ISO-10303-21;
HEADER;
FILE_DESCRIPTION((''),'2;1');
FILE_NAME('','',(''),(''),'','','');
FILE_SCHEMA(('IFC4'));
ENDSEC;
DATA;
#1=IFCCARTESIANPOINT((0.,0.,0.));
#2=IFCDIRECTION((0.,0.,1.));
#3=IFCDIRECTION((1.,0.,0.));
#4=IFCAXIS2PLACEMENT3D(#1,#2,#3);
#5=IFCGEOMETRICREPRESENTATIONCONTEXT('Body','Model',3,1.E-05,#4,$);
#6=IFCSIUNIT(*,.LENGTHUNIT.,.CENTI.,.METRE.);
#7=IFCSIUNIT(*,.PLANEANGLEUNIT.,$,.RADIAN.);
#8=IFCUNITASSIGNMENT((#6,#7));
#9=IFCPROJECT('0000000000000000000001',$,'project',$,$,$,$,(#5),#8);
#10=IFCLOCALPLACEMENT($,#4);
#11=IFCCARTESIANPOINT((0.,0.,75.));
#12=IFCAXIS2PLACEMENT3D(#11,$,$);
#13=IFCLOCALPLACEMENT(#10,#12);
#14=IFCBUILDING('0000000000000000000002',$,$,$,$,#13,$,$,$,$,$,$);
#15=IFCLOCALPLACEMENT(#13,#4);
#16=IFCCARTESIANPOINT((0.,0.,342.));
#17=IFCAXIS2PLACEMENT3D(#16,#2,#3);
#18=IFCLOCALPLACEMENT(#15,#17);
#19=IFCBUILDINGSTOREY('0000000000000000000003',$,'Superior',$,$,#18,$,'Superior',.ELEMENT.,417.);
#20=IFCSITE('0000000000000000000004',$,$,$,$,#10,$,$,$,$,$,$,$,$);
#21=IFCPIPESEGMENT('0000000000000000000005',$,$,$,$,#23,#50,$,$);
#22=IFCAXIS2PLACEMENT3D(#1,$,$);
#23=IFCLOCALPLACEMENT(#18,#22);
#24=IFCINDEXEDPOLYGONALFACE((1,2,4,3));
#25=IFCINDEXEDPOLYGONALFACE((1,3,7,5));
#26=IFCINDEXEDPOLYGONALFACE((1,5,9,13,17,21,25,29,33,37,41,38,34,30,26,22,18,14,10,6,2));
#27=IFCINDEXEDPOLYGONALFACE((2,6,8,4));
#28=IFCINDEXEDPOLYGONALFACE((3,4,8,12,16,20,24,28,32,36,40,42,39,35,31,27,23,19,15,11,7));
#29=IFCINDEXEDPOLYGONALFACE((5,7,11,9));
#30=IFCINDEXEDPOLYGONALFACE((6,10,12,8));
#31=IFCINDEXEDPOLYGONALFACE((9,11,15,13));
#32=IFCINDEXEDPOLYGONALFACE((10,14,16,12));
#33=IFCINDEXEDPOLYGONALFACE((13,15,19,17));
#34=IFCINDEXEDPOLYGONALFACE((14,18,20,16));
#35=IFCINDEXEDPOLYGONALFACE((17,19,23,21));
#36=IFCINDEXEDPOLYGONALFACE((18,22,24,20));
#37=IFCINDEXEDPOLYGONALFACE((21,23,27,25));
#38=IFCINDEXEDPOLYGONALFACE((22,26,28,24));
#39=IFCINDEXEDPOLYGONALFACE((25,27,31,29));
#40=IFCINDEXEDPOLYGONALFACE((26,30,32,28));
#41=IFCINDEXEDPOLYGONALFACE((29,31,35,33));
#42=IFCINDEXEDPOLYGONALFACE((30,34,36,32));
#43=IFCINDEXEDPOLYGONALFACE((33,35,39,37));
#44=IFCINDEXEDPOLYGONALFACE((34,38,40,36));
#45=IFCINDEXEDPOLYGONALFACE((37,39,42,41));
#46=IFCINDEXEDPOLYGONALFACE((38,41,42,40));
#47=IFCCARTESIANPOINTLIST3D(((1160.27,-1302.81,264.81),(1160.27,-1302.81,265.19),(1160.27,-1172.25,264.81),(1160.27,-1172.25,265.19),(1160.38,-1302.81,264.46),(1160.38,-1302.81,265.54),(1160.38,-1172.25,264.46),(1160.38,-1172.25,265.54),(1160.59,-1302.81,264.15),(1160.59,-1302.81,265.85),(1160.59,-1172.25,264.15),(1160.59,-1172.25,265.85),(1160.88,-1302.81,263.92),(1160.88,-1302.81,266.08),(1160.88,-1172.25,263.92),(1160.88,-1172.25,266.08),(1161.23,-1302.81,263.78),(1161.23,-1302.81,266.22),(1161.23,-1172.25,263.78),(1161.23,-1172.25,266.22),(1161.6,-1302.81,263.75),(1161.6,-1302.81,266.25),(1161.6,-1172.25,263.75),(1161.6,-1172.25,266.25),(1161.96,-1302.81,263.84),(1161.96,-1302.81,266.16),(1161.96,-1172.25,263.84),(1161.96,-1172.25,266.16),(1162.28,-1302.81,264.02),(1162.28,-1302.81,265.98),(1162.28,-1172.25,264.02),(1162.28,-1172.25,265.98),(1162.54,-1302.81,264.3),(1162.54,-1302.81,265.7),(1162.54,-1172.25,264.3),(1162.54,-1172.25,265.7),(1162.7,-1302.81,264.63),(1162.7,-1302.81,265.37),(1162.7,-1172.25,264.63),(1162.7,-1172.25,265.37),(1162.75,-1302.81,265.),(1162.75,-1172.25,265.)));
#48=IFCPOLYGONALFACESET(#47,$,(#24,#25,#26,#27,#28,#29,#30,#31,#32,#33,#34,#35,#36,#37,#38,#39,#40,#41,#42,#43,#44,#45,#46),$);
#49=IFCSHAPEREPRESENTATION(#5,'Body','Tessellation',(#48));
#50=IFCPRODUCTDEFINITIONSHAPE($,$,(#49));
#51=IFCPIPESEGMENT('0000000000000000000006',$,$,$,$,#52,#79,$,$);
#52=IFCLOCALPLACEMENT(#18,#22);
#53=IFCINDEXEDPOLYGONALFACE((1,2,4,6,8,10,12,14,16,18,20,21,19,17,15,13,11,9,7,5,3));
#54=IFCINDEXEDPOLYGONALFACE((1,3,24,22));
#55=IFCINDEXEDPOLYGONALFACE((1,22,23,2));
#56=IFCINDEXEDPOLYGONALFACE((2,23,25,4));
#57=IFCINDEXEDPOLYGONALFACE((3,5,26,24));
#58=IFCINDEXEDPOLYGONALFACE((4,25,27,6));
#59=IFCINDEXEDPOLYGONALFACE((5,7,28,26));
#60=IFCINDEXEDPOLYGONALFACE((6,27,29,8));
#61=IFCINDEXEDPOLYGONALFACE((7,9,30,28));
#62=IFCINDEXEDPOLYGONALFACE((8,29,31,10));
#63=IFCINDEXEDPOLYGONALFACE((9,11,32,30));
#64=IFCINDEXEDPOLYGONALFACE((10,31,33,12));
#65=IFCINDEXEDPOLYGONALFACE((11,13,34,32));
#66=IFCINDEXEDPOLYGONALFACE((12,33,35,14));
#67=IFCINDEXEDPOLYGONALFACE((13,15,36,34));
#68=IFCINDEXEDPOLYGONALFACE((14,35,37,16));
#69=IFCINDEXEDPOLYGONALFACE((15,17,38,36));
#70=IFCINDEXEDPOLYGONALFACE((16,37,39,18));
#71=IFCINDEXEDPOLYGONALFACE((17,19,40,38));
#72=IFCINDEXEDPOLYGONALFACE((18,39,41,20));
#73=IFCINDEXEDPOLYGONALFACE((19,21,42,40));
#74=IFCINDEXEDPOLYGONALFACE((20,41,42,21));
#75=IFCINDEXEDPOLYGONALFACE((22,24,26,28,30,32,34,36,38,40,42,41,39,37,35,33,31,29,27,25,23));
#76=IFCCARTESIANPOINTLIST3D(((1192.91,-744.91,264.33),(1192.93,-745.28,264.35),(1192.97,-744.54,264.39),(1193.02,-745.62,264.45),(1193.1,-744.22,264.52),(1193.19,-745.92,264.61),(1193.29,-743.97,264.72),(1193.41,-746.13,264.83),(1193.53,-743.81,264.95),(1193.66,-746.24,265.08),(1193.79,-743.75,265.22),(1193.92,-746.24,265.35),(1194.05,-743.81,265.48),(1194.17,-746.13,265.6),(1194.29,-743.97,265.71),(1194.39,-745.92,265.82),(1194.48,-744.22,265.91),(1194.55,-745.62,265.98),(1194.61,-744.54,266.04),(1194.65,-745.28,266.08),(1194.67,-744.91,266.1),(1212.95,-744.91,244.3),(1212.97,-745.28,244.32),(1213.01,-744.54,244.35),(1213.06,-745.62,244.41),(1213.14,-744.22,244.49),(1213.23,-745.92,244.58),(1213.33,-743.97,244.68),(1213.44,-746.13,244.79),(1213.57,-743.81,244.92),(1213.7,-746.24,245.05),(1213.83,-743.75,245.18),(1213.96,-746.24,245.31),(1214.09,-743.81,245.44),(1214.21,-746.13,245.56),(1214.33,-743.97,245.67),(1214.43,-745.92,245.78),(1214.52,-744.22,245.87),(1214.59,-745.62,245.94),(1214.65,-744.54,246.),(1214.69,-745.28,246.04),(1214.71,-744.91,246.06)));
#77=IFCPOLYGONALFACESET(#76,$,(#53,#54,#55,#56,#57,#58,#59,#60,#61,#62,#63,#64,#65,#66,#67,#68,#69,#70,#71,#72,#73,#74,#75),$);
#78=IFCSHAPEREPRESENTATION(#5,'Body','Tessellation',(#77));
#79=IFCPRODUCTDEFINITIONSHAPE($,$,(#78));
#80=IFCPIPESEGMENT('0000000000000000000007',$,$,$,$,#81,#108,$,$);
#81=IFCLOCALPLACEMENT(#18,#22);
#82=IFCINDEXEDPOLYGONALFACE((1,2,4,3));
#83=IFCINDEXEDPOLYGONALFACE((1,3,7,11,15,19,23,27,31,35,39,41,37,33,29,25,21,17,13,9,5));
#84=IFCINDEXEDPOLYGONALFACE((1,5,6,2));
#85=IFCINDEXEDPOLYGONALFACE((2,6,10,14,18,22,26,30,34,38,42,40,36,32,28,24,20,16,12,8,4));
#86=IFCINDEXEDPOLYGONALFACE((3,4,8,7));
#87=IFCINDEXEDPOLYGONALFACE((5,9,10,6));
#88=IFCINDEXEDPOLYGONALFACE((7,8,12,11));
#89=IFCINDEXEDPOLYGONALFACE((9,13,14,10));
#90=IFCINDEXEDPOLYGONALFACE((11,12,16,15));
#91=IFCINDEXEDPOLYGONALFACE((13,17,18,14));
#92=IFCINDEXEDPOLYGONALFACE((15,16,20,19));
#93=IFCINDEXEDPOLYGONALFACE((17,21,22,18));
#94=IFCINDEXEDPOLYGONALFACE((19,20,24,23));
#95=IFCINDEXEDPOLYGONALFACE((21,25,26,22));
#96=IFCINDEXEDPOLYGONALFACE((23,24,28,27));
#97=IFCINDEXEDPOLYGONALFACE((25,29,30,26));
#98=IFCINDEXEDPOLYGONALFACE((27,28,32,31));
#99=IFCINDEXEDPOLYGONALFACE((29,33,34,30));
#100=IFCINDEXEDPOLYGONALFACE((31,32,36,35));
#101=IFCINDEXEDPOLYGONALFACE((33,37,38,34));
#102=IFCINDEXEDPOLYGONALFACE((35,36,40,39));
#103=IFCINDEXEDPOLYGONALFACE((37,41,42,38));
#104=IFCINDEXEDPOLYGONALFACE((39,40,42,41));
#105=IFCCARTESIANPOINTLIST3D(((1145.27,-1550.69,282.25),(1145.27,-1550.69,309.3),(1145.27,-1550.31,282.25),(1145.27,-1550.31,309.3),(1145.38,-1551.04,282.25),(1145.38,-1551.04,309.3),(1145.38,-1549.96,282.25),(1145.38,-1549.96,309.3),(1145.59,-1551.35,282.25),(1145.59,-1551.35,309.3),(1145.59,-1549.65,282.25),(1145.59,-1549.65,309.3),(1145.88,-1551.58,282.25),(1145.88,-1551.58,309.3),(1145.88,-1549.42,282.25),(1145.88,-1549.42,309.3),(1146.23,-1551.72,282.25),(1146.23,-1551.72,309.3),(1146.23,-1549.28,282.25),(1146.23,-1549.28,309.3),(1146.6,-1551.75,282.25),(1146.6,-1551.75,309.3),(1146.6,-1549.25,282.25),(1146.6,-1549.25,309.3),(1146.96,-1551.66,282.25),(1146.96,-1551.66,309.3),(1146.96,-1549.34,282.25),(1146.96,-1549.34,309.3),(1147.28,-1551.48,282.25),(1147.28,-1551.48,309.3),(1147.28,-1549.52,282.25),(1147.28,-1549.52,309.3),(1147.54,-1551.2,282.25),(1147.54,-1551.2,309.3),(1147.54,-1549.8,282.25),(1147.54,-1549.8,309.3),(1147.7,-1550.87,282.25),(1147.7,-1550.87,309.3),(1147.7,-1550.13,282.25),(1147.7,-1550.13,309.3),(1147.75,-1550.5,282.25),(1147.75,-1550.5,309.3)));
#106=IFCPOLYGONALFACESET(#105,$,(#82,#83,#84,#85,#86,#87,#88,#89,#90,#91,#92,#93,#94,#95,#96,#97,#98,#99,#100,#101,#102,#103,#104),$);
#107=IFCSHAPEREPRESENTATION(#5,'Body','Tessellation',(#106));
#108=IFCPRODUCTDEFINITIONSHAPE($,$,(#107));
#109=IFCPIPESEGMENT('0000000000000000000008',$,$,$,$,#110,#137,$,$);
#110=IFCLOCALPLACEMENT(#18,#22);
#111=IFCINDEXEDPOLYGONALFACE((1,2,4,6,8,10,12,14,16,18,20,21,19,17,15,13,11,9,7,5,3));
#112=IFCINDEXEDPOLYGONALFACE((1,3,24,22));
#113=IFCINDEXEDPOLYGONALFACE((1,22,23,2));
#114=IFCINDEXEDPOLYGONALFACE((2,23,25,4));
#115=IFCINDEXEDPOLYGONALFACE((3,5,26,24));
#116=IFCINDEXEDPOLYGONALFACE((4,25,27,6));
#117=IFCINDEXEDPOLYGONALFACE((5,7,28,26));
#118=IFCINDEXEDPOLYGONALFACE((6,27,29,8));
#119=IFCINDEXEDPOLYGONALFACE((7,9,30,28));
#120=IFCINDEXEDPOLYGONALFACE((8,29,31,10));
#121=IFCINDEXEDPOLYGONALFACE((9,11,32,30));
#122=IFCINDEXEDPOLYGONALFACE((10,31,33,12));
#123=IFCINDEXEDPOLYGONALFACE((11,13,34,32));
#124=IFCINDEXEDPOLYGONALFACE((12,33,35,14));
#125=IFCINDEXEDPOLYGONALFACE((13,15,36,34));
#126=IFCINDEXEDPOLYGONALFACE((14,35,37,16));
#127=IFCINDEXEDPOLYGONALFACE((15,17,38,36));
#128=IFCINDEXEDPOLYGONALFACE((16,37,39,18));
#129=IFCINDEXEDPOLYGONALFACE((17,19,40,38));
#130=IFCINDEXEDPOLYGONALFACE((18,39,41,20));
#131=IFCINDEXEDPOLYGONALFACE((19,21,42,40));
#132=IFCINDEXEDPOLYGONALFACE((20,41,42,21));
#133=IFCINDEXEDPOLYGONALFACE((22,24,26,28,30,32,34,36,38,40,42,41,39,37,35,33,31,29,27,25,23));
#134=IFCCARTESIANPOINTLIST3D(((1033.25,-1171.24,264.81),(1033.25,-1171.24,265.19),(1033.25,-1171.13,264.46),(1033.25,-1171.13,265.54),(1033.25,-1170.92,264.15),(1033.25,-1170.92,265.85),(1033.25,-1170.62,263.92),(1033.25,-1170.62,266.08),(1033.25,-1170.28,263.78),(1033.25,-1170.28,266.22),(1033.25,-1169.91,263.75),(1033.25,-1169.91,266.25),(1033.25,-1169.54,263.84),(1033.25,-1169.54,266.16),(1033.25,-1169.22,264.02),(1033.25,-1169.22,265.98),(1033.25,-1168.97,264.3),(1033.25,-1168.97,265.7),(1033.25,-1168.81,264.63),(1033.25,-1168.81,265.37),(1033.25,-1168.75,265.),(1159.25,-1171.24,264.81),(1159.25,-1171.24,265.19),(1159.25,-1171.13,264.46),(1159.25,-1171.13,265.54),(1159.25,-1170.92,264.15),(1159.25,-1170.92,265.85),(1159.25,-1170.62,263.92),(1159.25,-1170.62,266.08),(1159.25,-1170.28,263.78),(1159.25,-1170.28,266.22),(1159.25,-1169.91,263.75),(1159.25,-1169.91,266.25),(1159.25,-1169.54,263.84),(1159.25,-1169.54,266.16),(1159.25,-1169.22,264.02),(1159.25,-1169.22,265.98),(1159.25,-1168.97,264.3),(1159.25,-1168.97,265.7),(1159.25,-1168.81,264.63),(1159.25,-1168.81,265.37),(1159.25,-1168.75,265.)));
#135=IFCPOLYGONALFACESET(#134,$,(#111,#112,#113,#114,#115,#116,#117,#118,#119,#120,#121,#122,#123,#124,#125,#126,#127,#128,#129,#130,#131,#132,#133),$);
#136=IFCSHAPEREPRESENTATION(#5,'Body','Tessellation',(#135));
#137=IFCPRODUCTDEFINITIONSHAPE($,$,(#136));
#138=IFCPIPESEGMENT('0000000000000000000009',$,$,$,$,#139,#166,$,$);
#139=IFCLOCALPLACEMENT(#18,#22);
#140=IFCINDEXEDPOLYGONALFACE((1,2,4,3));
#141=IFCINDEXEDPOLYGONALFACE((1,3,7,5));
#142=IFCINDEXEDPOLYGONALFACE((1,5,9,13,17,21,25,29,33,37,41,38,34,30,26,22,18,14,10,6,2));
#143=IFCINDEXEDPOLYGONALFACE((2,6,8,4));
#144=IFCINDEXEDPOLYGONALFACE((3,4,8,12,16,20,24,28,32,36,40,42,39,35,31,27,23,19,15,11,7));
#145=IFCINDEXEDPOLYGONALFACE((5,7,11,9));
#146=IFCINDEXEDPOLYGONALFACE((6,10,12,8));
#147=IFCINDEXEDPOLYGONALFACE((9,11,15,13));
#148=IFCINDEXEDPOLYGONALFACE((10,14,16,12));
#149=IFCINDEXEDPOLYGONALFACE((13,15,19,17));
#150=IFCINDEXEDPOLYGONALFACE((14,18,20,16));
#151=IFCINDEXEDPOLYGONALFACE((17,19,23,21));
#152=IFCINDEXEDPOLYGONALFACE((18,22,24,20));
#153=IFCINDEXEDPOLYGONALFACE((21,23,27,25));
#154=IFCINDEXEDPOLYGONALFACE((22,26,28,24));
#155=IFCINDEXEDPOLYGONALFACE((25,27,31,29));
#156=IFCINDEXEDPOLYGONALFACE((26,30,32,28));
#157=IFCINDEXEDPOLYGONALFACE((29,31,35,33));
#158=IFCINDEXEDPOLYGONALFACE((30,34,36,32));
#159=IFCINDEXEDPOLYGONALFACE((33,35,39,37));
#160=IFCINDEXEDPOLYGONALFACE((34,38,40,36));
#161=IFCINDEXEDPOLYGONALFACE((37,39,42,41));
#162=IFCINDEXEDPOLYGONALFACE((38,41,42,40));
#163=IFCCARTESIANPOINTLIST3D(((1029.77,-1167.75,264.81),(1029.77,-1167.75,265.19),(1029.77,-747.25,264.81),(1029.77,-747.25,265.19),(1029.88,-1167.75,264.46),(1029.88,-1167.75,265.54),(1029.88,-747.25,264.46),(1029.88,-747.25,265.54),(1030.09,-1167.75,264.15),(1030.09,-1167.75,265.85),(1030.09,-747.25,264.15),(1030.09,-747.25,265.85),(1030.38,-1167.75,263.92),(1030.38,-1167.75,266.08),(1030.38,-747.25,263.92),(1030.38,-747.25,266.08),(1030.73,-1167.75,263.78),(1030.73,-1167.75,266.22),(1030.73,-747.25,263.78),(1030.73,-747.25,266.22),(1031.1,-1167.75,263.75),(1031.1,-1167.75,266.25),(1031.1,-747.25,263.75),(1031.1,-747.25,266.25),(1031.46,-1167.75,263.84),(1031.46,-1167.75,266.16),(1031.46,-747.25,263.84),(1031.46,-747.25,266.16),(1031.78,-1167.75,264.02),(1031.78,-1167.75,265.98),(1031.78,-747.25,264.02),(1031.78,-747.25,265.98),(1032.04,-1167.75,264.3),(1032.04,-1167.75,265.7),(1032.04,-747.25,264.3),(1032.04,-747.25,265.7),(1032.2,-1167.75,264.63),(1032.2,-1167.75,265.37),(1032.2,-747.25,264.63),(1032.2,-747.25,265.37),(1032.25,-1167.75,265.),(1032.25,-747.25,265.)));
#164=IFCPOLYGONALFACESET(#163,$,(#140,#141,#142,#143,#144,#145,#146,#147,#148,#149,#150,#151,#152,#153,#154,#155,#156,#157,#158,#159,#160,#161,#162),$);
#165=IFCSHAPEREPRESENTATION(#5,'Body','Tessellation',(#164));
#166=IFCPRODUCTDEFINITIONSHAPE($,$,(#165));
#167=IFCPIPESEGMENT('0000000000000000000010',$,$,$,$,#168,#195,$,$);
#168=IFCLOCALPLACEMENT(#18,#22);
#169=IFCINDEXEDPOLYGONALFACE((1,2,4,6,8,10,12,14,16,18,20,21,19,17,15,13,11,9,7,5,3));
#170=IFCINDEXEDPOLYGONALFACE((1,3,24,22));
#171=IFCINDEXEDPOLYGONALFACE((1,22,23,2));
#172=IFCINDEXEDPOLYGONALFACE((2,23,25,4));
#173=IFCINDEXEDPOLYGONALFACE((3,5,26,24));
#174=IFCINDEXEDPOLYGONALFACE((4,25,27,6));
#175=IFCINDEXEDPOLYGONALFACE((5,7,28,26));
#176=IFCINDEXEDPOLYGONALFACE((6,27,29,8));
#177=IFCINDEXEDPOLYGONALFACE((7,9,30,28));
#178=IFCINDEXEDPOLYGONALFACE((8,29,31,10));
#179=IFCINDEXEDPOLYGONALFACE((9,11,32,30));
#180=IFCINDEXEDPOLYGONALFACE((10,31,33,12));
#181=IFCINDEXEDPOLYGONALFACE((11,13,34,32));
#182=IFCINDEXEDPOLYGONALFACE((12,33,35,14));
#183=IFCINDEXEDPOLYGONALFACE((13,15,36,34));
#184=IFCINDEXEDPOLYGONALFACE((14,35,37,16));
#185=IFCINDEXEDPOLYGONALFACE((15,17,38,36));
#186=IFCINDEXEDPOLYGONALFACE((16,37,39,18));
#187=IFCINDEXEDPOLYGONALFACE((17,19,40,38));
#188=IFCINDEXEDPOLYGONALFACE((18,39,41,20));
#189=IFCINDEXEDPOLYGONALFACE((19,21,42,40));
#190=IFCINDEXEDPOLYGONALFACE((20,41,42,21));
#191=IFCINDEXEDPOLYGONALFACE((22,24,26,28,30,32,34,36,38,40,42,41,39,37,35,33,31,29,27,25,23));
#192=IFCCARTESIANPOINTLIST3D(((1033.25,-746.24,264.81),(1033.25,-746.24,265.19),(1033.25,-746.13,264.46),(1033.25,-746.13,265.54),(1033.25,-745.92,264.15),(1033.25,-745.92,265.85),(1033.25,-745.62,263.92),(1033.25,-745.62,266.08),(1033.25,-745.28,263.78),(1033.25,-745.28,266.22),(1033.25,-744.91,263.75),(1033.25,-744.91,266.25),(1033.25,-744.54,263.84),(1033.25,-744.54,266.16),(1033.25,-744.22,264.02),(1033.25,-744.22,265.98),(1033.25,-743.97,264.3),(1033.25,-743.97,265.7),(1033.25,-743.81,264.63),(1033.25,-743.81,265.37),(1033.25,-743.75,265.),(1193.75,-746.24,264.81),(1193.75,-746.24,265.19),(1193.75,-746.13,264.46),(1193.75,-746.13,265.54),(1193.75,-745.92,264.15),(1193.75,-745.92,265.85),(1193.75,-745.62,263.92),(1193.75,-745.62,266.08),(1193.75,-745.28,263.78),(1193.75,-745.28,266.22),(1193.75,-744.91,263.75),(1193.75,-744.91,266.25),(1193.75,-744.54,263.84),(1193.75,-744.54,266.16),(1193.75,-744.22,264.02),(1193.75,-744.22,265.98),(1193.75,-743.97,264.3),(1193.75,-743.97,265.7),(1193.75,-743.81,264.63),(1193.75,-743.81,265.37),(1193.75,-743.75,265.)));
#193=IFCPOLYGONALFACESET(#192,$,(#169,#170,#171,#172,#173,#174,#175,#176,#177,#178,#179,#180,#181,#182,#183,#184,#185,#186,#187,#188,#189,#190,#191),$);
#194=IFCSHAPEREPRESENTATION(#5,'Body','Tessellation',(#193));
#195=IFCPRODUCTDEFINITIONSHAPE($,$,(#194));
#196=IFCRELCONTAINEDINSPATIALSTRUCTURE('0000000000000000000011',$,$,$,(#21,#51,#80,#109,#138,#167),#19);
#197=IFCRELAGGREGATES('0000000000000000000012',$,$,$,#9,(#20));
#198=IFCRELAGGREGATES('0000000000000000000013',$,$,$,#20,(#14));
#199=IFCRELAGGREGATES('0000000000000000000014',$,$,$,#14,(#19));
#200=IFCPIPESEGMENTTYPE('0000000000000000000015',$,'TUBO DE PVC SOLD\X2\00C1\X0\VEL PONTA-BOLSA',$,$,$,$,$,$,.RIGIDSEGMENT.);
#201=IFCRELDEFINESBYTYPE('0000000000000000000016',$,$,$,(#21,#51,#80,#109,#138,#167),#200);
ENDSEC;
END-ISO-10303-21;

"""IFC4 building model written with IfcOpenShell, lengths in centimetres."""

from ifc_helpers import new_model, si_unit, frame, origin_with_axes, origin_2d_with_axis, place, context, project, spatial, circle, extrude, type_object, element, save


model = new_model("IFC4")

# Units and contexts
model_context = context("Model", 3, precision=1e-05, world=origin_with_axes(), identifier="Body")
ifc_project = project(units=[si_unit("LENGTHUNIT", "METRE", prefix="CENTI"), si_unit("PLANEANGLEUNIT", "RADIAN")], contexts=[model_context])

# Site, building, storey
site_placement = place(None, origin_with_axes())
site = spatial("IfcSite", under=ifc_project, at=site_placement)
building_placement = place(site_placement, frame((0.0, 0.0, 75.0)))
building = spatial("IfcBuilding", under=site, at=building_placement)
placement = place(building_placement, origin_with_axes())
storey_placement = place(placement, frame((0.0, 0.0, 342.0), z_axis=(0.0, 0.0, 1.0), x_axis=(1.0, 0.0, 0.0)))
storey = spatial("IfcBuildingStorey", under=building, at=storey_placement, Name="Superior", LongName="Superior", CompositionType="ELEMENT", Elevation=417.0)

# Pipe segments
pipe_segment_type_1 = type_object("IfcPipeSegmentType", Name="TUBO DE PVC SOLDÁVEL PONTA-BOLSA", PredefinedType="RIGIDSEGMENT")
pipe_segment_1_placement = place(storey_placement, frame((1161.5, -1237.53, 266.25), z_axis=(0.0, 0.0, 1.0), x_axis=(1.0, 0.0, 0.0)))
element("IfcPipeSegment", 1, at=pipe_segment_1_placement, inside=storey, type_object=pipe_segment_type_1, context=model_context, shape_type="SolidModel", body=[
    extrude(circle(Radius=1.25, at=origin_2d_with_axis()), frame((0.0, -65.28, -1.25), z_axis=(0.0, 1.0, 0.0), x_axis=(1.0, 0.0, 0.0)), (0.0, 0.0, 1.0), 130.56),
])
pipe_segment_2_placement = place(storey_placement, frame((1203.81, -745.0, 266.1), z_axis=(0.0, 0.0, 1.0), x_axis=(1.0, 0.0, 0.0)))
element("IfcPipeSegment", 2, at=pipe_segment_2_placement, inside=storey, type_object=pipe_segment_type_1, context=model_context, shape_type="SolidModel", body=[
    extrude(circle(Radius=1.25, at=origin_2d_with_axis()), frame((-10.02, 0.0, -0.88), z_axis=(0.707107, 0.0, -0.707107), x_axis=(0.0, 1.0, 0.0)), (0.0, 0.0, 1.0), 28.34),
])
pipe_segment_3_placement = place(storey_placement, frame((1146.5, -1550.5, 309.3), z_axis=(0.0, 0.0, 1.0), x_axis=(1.0, 0.0, 0.0)))
element("IfcPipeSegment", 3, at=pipe_segment_3_placement, inside=storey, type_object=pipe_segment_type_1, context=model_context, shape_type="SolidModel", body=[
    extrude(circle(Radius=1.25, at=origin_2d_with_axis()), frame((0.0, 0.0, -27.05), z_axis=(0.0, 0.000012, 1.0), x_axis=(1.0, 0.0, 0.0)), (0.0, 0.0, 1.0), 27.05),
])
pipe_segment_4_placement = place(storey_placement, frame((1096.25, -1170.0, 266.25), z_axis=(0.0, 0.0, 1.0), x_axis=(1.0, 0.0, 0.0)))
element("IfcPipeSegment", 4, at=pipe_segment_4_placement, inside=storey, type_object=pipe_segment_type_1, context=model_context, shape_type="SolidModel", body=[
    extrude(circle(Radius=1.25, at=origin_2d_with_axis()), frame((63.0, 0.0, -1.25), z_axis=(-1.0, 0.0, 0.0), x_axis=(0.0, 1.0, 0.0)), (0.0, 0.0, 1.0), 126.0),
])
pipe_segment_5_placement = place(storey_placement, frame((1031.0, -957.5, 266.25), z_axis=(0.0, 0.0, 1.0), x_axis=(1.0, 0.0, 0.0)))
element("IfcPipeSegment", 5, at=pipe_segment_5_placement, inside=storey, type_object=pipe_segment_type_1, context=model_context, shape_type="SolidModel", body=[
    extrude(circle(Radius=1.25, at=origin_2d_with_axis()), frame((0.0, -210.25, -1.25), z_axis=(0.0, 1.0, 0.0), x_axis=(1.0, 0.0, 0.0)), (0.0, 0.0, 1.0), 420.5),
])
pipe_segment_6_placement = place(storey_placement, frame((1113.5, -745.0, 266.25), z_axis=(0.0, 0.0, 1.0), x_axis=(1.0, 0.0, 0.0)))
element("IfcPipeSegment", 6, at=pipe_segment_6_placement, inside=storey, type_object=pipe_segment_type_1, context=model_context, shape_type="SolidModel", body=[
    extrude(circle(Radius=1.25, at=origin_2d_with_axis()), frame((-80.25, 0.0, -1.25), z_axis=(1.0, 0.0, 0.0), x_axis=(0.0, 1.0, 0.0)), (0.0, 0.0, 1.0), 160.5),
])

save(model, "model.ifc")
